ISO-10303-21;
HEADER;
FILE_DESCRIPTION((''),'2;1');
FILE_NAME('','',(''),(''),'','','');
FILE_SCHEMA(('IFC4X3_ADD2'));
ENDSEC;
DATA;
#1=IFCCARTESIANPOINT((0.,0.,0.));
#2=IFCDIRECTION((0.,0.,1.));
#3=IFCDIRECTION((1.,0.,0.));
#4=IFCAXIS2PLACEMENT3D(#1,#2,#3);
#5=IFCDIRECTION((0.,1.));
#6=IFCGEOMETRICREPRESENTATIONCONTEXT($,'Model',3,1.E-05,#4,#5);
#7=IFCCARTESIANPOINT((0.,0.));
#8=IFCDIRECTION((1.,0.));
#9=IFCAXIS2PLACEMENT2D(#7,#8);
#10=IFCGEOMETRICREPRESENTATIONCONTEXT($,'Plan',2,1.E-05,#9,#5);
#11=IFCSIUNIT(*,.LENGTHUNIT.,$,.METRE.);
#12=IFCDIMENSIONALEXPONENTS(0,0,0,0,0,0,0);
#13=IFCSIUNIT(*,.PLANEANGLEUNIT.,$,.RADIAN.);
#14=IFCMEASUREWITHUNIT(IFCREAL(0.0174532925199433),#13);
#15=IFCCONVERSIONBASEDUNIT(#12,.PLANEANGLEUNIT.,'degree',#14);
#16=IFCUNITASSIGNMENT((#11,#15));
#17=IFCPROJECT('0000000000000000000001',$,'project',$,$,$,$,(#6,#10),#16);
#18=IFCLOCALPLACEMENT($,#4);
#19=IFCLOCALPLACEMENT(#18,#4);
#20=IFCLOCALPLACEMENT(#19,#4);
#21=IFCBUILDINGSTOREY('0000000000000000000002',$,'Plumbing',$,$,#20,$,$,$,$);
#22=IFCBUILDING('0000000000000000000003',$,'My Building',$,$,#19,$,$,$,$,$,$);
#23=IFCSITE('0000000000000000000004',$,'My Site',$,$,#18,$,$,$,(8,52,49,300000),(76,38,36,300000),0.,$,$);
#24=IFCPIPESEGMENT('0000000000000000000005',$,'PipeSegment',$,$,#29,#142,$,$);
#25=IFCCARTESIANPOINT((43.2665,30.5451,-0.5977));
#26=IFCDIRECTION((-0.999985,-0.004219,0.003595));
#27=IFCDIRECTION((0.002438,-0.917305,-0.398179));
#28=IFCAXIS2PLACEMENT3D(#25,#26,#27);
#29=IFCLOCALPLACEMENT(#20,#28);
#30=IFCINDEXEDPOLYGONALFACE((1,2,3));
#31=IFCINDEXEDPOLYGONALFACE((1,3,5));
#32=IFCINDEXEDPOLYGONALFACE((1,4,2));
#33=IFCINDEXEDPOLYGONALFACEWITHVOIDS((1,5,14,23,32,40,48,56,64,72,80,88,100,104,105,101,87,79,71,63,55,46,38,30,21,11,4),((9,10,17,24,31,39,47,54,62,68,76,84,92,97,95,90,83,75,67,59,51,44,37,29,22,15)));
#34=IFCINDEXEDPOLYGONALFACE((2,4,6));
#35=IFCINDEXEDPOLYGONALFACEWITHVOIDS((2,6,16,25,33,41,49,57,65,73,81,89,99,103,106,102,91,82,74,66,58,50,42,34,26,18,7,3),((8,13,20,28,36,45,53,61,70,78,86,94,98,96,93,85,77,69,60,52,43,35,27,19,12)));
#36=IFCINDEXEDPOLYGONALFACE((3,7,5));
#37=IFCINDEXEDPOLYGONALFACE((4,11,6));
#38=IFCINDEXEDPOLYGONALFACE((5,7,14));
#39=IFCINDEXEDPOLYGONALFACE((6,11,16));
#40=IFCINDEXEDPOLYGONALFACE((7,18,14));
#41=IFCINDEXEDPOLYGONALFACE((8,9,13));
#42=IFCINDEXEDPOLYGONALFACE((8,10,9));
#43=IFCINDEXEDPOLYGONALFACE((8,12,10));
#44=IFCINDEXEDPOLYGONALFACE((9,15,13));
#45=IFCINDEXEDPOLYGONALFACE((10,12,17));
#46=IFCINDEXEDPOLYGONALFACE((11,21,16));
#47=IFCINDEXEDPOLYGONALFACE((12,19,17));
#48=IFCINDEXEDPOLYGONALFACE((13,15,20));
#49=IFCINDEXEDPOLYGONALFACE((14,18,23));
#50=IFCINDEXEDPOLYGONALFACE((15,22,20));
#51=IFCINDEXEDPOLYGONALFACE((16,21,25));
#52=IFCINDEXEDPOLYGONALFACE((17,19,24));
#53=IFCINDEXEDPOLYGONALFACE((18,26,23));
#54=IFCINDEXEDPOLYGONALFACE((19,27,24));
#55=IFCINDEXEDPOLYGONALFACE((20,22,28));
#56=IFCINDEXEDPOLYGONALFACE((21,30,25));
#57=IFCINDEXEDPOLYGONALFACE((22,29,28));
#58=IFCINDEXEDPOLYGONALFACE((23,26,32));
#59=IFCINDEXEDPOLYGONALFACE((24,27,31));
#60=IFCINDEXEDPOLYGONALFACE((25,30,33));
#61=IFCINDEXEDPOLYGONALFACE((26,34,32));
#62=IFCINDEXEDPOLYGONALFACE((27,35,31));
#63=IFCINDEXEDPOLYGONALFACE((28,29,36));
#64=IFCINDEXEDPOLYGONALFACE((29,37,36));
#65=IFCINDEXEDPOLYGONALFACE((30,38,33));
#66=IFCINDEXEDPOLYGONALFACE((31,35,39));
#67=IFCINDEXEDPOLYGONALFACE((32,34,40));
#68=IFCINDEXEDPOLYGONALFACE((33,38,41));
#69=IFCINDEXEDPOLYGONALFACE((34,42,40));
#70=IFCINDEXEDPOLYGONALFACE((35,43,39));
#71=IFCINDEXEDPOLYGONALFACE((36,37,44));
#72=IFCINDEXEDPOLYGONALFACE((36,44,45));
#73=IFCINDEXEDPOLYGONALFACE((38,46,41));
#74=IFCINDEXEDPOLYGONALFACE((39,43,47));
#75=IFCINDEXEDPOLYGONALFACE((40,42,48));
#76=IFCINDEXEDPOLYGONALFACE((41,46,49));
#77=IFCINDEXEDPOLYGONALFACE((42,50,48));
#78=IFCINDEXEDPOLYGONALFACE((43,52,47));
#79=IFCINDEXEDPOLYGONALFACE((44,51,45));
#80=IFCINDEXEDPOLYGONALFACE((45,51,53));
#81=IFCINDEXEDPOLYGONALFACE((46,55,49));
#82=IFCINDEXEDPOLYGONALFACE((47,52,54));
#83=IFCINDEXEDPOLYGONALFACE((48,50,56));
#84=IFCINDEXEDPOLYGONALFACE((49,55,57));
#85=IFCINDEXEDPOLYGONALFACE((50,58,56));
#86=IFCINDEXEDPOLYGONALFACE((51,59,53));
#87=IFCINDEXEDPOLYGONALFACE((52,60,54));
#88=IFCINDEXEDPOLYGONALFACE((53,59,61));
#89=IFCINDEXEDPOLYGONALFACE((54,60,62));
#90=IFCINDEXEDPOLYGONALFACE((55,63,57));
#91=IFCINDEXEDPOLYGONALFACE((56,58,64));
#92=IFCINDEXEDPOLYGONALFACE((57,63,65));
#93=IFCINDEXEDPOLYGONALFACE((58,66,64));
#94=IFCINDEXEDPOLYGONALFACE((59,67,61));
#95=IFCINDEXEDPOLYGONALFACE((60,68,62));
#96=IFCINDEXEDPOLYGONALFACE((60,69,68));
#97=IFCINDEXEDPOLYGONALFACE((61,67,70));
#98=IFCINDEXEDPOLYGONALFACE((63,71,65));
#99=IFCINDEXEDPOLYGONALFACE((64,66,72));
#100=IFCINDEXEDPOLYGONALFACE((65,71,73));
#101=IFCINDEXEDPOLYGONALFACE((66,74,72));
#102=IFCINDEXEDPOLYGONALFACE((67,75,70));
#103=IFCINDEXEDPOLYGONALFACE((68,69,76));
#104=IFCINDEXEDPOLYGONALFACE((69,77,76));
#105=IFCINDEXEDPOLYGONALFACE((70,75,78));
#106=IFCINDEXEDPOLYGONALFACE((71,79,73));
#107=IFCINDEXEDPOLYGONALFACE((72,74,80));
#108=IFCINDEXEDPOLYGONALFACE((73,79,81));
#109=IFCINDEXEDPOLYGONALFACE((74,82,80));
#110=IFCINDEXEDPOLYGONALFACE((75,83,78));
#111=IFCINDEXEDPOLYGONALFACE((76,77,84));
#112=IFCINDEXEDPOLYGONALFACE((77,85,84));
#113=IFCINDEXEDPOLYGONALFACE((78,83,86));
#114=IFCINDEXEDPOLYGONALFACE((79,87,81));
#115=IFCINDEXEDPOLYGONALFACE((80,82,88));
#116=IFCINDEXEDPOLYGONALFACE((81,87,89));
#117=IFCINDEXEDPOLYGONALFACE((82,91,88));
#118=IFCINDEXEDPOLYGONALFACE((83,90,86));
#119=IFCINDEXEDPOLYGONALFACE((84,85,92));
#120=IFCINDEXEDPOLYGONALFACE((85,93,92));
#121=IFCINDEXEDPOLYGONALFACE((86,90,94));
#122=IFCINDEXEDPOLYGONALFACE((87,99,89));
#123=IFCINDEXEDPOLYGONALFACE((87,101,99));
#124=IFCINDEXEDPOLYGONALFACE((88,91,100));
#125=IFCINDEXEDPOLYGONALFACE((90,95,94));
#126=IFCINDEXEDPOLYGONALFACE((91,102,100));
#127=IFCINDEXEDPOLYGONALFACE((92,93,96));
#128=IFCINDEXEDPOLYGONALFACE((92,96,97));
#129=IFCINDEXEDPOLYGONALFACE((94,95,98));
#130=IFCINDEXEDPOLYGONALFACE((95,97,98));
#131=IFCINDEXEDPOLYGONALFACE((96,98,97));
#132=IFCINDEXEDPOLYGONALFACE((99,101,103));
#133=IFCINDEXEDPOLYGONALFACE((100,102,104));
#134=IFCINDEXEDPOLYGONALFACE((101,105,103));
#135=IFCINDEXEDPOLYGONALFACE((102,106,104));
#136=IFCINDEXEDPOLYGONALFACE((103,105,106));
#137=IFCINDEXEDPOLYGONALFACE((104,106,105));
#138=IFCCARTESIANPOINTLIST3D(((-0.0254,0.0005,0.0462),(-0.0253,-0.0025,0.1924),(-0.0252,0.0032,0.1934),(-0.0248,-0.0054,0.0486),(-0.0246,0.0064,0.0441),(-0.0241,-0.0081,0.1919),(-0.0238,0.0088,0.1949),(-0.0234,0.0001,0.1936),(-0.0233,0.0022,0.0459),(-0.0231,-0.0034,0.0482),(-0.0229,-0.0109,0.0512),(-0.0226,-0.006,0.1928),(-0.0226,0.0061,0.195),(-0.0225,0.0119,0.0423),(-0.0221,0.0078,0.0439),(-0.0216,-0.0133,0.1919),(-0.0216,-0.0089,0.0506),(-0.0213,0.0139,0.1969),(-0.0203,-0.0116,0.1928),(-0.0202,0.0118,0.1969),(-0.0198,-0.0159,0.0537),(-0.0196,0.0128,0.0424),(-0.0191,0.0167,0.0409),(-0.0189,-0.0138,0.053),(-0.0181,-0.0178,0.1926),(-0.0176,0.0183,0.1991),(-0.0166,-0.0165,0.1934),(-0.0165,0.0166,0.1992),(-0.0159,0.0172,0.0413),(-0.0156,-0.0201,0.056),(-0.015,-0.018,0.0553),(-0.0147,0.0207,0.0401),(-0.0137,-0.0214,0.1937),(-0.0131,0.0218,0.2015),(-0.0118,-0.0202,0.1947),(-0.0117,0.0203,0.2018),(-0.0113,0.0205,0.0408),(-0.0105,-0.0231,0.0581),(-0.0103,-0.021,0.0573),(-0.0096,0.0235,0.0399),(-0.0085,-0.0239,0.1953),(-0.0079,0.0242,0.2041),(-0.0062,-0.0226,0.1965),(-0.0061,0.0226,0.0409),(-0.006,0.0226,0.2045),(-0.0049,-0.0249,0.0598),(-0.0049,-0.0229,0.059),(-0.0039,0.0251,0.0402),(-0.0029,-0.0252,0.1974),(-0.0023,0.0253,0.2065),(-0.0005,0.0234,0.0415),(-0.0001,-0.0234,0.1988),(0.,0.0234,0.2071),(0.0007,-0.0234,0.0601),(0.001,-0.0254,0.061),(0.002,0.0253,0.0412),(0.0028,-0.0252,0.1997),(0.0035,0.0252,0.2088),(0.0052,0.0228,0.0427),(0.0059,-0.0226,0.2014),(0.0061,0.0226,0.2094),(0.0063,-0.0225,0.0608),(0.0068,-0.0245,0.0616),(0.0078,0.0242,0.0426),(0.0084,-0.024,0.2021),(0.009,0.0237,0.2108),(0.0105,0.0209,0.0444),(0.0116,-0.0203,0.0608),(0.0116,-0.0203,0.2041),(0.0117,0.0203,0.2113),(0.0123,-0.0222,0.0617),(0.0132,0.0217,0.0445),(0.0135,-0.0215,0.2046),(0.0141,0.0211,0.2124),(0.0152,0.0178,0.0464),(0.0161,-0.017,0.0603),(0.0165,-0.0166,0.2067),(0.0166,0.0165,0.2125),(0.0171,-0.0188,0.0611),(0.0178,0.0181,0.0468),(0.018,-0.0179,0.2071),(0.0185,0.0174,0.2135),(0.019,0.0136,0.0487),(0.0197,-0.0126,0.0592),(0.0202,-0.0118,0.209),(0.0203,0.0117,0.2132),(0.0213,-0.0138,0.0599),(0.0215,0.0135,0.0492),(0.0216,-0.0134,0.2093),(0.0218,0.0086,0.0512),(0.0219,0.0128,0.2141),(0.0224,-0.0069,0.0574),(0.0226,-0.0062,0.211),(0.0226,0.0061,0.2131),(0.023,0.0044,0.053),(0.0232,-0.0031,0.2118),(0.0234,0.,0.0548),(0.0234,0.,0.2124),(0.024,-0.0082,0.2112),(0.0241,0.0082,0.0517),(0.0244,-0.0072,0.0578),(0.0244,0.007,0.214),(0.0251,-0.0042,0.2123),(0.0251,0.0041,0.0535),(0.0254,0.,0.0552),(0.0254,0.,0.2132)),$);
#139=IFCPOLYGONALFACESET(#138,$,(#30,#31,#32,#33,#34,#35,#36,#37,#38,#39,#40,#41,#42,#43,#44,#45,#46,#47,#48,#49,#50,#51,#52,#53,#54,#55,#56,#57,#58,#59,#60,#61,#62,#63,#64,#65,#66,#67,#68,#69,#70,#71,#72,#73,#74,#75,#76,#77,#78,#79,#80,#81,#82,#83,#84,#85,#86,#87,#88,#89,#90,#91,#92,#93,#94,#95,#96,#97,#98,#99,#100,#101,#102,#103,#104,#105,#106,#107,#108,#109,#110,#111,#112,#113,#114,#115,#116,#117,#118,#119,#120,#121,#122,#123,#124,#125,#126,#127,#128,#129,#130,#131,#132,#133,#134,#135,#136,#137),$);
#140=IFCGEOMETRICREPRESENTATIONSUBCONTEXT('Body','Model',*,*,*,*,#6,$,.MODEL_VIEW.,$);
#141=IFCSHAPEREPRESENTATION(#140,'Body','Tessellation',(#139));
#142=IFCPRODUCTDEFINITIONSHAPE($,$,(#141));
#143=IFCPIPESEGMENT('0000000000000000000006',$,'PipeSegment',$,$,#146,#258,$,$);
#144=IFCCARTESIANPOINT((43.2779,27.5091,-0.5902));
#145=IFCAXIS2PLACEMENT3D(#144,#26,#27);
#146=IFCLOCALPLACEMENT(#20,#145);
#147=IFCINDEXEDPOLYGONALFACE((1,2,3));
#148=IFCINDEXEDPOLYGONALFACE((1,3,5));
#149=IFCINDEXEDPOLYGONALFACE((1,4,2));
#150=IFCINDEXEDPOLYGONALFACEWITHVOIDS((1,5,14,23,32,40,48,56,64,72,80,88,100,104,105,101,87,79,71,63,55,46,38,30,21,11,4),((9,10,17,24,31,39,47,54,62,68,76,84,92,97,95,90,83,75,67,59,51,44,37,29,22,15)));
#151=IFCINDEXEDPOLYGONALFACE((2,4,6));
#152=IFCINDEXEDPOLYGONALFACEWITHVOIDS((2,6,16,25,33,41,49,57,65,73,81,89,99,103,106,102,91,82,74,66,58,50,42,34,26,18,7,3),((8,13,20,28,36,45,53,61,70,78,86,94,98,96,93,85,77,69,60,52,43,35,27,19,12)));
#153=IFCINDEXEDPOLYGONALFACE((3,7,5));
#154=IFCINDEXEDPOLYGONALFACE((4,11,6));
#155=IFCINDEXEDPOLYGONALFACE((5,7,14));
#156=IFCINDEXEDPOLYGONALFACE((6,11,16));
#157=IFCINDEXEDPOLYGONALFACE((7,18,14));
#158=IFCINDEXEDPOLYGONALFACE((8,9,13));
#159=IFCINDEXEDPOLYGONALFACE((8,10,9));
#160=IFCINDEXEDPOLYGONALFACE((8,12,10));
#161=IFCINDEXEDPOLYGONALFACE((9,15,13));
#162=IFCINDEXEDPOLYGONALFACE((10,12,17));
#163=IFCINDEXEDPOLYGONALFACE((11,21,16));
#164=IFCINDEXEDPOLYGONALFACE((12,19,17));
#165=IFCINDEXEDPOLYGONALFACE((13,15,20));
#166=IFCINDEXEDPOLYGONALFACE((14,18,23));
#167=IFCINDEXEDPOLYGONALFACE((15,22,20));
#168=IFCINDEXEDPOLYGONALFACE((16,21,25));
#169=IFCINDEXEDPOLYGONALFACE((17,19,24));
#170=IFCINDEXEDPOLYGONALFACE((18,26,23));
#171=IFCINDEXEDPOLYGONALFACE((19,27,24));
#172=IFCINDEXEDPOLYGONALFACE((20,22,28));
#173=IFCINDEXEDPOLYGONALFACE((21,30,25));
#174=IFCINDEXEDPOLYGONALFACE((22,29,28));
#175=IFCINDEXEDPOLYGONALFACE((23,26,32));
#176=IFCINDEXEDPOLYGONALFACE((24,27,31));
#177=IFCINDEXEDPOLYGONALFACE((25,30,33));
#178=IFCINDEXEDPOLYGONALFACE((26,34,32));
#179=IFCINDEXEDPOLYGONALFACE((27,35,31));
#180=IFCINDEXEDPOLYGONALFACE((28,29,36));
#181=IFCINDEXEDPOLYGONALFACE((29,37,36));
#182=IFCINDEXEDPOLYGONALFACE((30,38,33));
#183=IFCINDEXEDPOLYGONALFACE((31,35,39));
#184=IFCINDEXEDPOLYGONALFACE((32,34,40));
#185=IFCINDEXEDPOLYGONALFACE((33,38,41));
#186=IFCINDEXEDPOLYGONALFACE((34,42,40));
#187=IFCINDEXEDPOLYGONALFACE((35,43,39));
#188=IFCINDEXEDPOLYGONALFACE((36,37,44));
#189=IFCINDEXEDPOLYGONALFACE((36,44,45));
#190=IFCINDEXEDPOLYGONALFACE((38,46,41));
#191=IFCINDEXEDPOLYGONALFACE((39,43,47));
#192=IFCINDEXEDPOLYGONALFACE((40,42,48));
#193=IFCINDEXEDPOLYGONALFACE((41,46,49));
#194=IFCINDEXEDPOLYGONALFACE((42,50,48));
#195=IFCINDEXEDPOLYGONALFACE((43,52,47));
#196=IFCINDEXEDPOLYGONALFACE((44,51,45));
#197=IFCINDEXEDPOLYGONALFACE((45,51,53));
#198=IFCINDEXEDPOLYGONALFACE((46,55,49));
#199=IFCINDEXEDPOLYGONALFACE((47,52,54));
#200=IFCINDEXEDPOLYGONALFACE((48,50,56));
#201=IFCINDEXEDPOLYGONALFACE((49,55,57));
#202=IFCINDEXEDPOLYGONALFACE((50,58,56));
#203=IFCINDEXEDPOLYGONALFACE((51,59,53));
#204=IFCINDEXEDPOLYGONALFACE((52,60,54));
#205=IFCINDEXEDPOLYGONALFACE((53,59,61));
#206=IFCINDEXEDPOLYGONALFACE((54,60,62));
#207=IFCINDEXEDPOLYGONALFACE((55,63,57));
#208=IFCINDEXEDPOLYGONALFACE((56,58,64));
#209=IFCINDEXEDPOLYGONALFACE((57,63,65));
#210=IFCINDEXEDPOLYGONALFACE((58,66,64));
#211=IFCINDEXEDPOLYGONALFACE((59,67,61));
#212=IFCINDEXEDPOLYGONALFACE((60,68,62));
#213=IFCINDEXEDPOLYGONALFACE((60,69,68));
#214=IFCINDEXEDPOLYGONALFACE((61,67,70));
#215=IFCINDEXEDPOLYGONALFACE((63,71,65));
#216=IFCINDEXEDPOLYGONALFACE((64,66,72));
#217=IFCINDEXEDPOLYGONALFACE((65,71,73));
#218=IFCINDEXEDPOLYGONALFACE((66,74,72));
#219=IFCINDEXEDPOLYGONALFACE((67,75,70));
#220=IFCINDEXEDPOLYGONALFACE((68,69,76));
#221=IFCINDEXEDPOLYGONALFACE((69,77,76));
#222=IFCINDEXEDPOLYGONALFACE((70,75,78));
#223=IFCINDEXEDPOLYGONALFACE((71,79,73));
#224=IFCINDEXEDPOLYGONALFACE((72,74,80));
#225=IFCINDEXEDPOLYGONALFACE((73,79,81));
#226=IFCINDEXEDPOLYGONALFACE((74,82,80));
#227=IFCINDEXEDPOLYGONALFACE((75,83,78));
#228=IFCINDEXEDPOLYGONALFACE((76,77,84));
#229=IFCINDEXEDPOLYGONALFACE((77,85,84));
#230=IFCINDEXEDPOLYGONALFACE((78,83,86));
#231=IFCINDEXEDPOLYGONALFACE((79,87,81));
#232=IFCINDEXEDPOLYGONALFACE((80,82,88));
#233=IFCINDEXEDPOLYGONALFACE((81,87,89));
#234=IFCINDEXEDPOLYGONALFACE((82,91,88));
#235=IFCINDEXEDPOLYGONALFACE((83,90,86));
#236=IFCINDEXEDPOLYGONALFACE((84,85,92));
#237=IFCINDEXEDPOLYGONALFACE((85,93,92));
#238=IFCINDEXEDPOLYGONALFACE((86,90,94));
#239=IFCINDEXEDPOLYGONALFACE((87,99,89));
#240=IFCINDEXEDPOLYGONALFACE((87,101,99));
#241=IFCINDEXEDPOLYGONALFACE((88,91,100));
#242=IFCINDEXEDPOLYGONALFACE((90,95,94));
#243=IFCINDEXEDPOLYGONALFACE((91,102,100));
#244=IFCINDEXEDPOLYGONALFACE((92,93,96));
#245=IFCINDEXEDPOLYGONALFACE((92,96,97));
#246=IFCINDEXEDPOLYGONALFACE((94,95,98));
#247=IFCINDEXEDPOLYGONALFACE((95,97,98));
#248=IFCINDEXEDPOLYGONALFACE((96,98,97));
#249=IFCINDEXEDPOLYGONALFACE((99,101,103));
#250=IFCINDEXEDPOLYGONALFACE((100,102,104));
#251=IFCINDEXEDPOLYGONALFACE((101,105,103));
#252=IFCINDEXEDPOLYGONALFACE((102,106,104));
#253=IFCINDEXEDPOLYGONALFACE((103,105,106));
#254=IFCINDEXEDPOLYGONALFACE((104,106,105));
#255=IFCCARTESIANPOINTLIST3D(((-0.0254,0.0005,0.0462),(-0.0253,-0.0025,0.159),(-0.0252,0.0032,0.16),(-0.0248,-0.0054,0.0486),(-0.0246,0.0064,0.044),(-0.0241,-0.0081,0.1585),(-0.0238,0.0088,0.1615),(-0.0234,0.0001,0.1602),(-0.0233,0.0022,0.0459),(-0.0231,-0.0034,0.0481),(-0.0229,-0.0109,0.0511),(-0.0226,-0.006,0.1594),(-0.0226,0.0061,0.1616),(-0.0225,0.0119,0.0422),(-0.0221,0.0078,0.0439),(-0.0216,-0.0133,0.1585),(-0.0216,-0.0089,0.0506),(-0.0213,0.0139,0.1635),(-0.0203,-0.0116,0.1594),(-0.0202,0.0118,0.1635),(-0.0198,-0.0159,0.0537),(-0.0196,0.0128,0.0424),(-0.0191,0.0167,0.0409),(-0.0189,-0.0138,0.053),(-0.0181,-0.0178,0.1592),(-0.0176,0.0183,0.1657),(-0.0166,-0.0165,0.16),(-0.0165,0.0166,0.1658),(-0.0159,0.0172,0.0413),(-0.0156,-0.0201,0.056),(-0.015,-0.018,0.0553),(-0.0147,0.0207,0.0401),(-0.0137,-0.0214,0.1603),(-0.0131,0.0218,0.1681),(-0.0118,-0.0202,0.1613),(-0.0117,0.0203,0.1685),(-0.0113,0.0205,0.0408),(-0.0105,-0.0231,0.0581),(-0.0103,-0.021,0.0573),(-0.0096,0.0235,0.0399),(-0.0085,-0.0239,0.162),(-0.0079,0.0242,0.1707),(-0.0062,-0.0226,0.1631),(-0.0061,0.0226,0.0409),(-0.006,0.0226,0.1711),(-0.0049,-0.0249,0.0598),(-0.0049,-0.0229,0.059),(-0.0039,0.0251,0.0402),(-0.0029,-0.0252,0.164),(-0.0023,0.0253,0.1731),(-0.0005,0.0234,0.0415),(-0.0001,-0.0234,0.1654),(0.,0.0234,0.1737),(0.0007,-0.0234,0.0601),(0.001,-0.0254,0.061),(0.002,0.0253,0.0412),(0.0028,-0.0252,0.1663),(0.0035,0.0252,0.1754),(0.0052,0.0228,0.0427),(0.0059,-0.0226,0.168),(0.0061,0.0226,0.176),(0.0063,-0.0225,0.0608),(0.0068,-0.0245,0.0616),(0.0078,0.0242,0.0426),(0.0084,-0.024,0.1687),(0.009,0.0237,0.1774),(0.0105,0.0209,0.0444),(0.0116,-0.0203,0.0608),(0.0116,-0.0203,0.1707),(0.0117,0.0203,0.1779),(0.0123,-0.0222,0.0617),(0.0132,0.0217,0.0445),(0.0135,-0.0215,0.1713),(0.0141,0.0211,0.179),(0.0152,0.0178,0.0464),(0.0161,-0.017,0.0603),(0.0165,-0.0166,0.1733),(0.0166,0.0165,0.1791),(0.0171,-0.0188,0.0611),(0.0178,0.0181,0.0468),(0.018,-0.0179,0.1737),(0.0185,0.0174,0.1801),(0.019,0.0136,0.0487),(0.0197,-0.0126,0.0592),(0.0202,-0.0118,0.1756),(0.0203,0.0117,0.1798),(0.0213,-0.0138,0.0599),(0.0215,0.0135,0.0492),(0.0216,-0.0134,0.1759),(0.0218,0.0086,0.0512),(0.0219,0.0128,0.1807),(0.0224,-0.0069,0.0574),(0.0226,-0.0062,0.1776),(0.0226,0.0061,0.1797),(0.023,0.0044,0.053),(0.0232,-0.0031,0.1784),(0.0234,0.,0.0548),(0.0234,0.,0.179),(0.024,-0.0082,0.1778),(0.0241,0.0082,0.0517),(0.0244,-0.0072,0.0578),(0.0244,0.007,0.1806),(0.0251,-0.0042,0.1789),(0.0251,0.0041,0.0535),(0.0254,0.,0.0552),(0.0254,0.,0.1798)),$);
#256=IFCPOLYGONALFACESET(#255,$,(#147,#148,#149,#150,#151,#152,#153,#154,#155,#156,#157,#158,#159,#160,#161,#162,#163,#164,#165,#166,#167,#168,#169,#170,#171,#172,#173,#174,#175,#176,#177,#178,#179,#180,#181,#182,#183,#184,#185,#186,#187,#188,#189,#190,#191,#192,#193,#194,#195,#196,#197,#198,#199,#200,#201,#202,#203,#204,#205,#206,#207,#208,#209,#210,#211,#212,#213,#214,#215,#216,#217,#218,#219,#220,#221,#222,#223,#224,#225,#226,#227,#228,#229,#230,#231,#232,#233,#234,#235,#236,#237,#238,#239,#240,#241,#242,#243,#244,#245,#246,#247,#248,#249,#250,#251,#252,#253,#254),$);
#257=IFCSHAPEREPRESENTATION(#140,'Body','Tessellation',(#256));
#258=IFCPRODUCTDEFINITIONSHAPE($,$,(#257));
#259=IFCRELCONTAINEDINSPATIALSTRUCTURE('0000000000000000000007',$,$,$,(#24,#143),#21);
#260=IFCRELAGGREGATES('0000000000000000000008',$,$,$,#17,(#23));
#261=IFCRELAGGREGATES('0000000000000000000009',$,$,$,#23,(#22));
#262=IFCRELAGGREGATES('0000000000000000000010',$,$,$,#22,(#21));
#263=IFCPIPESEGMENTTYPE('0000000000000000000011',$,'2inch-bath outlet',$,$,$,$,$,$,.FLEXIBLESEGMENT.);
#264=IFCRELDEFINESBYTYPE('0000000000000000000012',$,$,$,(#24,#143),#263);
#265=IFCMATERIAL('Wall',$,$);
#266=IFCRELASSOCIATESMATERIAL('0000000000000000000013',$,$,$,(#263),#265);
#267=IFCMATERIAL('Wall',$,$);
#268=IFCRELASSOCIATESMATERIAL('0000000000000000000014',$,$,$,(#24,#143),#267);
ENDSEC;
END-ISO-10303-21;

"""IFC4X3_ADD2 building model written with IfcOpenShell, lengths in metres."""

from ifc_helpers import new_model, entity, si_unit, converted_unit, direction, frame, origin_with_axes, origin_2d_with_axis, place, context, subcontext, project, spatial, hollow_circle, extrude, clip, halfspace, material, material_profile, profile_set, profile_usage, type_object, element, save


model = new_model("IFC4X3_ADD2")

# Units and contexts
model_context = context("Model", 3, precision=1e-05, world=origin_with_axes(), true_north=direction((0.0, 1.0)))
plan_context = context("Plan", 2, precision=1e-05, world=origin_2d_with_axis(), true_north=direction((0.0, 1.0)))
body_context = subcontext(model_context, "Body", "Model", "MODEL_VIEW")
ifc_project = project(units=[si_unit("LENGTHUNIT", "METRE"), converted_unit("PLANEANGLEUNIT", "degree", entity("IfcReal", 0.0174532925199433), si_unit("PLANEANGLEUNIT", "RADIAN"), dimensions=[0, 0, 0, 0, 0, 0, 0])], contexts=[model_context, plan_context])

# Site, building, storey
site_placement = place(None, origin_with_axes())
site = spatial("IfcSite", under=ifc_project, at=site_placement, Name="My Site", RefLatitude=(8, 52, 49, 300000), RefLongitude=(76, 38, 36, 300000), RefElevation=0.0)
building_placement = place(site_placement, origin_with_axes())
building = spatial("IfcBuilding", under=site, at=building_placement, Name="My Building")
storey_placement = place(building_placement, origin_with_axes())
storey = spatial("IfcBuildingStorey", under=building, at=storey_placement, Name="Plumbing")

# Pipe segments
ifc_material_1 = material(Name="Wall")
ifc_material_profile_1 = material_profile(ifc_material_1, hollow_circle(Radius=0.0254, WallThickness=0.002))
ifc_profile_set_1 = profile_set([ifc_material_profile_1], Name="graywater")
ifc_material_2 = material(Name="Wall")
ifc_material_profile_2 = material_profile(ifc_material_2, hollow_circle(Radius=0.0254, WallThickness=0.002))
ifc_profile_set_2 = profile_set([ifc_material_profile_2], Name="graywater")
pipe_segment_type_1 = type_object("IfcPipeSegmentType", Name="2inch-bath outlet", PredefinedType="FLEXIBLESEGMENT", material=ifc_profile_set_2)
ifc_profile_usage_1 = profile_usage(ifc_profile_set_1, cardinal=5)
pipe_segment_1_placement = place(storey_placement, frame((43.2665, 30.5451, -0.5977), z_axis=(-0.999985, -0.004219, 0.003595), x_axis=(0.002438, -0.917305, -0.398179)))
element("IfcPipeSegment", 1, at=pipe_segment_1_placement, inside=storey, type_object=pipe_segment_type_1, material=ifc_profile_usage_1, Name="PipeSegment", context=body_context, shape_type="Clipping", body=[
    clip(clip(extrude(hollow_circle(Radius=0.0254, WallThickness=0.002), origin_with_axes(), (0.0, 0.0, 1.0), 0.2538), halfspace(frame((-0.0679, -0.0376, 0.0539), z_axis=(0.158546, -0.361655, -0.918732), x_axis=(-0.915857, -0.401504, 0.0)), False)), halfspace(frame((0.003, -0.0252, 0.1997), z_axis=(-0.368459, -0.160869, 0.91562), x_axis=(-0.400126, 0.91646, 0.0)), False)),
])
ifc_profile_usage_2 = profile_usage(ifc_profile_set_1, cardinal=5)
pipe_segment_2_placement = place(storey_placement, frame((43.2779, 27.5091, -0.5902), z_axis=(-0.999985, -0.004219, 0.003595), x_axis=(0.002438, -0.917305, -0.398179)))
element("IfcPipeSegment", 2, at=pipe_segment_2_placement, inside=storey, type_object=pipe_segment_type_1, material=ifc_profile_usage_2, Name="PipeSegment", context=body_context, shape_type="Clipping", body=[
    clip(clip(extrude(hollow_circle(Radius=0.0254, WallThickness=0.002), origin_with_axes(), (0.0, 0.0, 1.0), 0.2204), halfspace(frame((0.0402, -0.0678, 0.1738), z_axis=(-0.368459, -0.160869, 0.91562), x_axis=(-0.400126, 0.91646, 0.0)), False)), halfspace(frame((-2.8499, -1.2534, 0.0524), z_axis=(0.158546, -0.361655, -0.918732), x_axis=(-0.915857, -0.401504, 0.0)), False)),
])

save(model, "model.ifc")
